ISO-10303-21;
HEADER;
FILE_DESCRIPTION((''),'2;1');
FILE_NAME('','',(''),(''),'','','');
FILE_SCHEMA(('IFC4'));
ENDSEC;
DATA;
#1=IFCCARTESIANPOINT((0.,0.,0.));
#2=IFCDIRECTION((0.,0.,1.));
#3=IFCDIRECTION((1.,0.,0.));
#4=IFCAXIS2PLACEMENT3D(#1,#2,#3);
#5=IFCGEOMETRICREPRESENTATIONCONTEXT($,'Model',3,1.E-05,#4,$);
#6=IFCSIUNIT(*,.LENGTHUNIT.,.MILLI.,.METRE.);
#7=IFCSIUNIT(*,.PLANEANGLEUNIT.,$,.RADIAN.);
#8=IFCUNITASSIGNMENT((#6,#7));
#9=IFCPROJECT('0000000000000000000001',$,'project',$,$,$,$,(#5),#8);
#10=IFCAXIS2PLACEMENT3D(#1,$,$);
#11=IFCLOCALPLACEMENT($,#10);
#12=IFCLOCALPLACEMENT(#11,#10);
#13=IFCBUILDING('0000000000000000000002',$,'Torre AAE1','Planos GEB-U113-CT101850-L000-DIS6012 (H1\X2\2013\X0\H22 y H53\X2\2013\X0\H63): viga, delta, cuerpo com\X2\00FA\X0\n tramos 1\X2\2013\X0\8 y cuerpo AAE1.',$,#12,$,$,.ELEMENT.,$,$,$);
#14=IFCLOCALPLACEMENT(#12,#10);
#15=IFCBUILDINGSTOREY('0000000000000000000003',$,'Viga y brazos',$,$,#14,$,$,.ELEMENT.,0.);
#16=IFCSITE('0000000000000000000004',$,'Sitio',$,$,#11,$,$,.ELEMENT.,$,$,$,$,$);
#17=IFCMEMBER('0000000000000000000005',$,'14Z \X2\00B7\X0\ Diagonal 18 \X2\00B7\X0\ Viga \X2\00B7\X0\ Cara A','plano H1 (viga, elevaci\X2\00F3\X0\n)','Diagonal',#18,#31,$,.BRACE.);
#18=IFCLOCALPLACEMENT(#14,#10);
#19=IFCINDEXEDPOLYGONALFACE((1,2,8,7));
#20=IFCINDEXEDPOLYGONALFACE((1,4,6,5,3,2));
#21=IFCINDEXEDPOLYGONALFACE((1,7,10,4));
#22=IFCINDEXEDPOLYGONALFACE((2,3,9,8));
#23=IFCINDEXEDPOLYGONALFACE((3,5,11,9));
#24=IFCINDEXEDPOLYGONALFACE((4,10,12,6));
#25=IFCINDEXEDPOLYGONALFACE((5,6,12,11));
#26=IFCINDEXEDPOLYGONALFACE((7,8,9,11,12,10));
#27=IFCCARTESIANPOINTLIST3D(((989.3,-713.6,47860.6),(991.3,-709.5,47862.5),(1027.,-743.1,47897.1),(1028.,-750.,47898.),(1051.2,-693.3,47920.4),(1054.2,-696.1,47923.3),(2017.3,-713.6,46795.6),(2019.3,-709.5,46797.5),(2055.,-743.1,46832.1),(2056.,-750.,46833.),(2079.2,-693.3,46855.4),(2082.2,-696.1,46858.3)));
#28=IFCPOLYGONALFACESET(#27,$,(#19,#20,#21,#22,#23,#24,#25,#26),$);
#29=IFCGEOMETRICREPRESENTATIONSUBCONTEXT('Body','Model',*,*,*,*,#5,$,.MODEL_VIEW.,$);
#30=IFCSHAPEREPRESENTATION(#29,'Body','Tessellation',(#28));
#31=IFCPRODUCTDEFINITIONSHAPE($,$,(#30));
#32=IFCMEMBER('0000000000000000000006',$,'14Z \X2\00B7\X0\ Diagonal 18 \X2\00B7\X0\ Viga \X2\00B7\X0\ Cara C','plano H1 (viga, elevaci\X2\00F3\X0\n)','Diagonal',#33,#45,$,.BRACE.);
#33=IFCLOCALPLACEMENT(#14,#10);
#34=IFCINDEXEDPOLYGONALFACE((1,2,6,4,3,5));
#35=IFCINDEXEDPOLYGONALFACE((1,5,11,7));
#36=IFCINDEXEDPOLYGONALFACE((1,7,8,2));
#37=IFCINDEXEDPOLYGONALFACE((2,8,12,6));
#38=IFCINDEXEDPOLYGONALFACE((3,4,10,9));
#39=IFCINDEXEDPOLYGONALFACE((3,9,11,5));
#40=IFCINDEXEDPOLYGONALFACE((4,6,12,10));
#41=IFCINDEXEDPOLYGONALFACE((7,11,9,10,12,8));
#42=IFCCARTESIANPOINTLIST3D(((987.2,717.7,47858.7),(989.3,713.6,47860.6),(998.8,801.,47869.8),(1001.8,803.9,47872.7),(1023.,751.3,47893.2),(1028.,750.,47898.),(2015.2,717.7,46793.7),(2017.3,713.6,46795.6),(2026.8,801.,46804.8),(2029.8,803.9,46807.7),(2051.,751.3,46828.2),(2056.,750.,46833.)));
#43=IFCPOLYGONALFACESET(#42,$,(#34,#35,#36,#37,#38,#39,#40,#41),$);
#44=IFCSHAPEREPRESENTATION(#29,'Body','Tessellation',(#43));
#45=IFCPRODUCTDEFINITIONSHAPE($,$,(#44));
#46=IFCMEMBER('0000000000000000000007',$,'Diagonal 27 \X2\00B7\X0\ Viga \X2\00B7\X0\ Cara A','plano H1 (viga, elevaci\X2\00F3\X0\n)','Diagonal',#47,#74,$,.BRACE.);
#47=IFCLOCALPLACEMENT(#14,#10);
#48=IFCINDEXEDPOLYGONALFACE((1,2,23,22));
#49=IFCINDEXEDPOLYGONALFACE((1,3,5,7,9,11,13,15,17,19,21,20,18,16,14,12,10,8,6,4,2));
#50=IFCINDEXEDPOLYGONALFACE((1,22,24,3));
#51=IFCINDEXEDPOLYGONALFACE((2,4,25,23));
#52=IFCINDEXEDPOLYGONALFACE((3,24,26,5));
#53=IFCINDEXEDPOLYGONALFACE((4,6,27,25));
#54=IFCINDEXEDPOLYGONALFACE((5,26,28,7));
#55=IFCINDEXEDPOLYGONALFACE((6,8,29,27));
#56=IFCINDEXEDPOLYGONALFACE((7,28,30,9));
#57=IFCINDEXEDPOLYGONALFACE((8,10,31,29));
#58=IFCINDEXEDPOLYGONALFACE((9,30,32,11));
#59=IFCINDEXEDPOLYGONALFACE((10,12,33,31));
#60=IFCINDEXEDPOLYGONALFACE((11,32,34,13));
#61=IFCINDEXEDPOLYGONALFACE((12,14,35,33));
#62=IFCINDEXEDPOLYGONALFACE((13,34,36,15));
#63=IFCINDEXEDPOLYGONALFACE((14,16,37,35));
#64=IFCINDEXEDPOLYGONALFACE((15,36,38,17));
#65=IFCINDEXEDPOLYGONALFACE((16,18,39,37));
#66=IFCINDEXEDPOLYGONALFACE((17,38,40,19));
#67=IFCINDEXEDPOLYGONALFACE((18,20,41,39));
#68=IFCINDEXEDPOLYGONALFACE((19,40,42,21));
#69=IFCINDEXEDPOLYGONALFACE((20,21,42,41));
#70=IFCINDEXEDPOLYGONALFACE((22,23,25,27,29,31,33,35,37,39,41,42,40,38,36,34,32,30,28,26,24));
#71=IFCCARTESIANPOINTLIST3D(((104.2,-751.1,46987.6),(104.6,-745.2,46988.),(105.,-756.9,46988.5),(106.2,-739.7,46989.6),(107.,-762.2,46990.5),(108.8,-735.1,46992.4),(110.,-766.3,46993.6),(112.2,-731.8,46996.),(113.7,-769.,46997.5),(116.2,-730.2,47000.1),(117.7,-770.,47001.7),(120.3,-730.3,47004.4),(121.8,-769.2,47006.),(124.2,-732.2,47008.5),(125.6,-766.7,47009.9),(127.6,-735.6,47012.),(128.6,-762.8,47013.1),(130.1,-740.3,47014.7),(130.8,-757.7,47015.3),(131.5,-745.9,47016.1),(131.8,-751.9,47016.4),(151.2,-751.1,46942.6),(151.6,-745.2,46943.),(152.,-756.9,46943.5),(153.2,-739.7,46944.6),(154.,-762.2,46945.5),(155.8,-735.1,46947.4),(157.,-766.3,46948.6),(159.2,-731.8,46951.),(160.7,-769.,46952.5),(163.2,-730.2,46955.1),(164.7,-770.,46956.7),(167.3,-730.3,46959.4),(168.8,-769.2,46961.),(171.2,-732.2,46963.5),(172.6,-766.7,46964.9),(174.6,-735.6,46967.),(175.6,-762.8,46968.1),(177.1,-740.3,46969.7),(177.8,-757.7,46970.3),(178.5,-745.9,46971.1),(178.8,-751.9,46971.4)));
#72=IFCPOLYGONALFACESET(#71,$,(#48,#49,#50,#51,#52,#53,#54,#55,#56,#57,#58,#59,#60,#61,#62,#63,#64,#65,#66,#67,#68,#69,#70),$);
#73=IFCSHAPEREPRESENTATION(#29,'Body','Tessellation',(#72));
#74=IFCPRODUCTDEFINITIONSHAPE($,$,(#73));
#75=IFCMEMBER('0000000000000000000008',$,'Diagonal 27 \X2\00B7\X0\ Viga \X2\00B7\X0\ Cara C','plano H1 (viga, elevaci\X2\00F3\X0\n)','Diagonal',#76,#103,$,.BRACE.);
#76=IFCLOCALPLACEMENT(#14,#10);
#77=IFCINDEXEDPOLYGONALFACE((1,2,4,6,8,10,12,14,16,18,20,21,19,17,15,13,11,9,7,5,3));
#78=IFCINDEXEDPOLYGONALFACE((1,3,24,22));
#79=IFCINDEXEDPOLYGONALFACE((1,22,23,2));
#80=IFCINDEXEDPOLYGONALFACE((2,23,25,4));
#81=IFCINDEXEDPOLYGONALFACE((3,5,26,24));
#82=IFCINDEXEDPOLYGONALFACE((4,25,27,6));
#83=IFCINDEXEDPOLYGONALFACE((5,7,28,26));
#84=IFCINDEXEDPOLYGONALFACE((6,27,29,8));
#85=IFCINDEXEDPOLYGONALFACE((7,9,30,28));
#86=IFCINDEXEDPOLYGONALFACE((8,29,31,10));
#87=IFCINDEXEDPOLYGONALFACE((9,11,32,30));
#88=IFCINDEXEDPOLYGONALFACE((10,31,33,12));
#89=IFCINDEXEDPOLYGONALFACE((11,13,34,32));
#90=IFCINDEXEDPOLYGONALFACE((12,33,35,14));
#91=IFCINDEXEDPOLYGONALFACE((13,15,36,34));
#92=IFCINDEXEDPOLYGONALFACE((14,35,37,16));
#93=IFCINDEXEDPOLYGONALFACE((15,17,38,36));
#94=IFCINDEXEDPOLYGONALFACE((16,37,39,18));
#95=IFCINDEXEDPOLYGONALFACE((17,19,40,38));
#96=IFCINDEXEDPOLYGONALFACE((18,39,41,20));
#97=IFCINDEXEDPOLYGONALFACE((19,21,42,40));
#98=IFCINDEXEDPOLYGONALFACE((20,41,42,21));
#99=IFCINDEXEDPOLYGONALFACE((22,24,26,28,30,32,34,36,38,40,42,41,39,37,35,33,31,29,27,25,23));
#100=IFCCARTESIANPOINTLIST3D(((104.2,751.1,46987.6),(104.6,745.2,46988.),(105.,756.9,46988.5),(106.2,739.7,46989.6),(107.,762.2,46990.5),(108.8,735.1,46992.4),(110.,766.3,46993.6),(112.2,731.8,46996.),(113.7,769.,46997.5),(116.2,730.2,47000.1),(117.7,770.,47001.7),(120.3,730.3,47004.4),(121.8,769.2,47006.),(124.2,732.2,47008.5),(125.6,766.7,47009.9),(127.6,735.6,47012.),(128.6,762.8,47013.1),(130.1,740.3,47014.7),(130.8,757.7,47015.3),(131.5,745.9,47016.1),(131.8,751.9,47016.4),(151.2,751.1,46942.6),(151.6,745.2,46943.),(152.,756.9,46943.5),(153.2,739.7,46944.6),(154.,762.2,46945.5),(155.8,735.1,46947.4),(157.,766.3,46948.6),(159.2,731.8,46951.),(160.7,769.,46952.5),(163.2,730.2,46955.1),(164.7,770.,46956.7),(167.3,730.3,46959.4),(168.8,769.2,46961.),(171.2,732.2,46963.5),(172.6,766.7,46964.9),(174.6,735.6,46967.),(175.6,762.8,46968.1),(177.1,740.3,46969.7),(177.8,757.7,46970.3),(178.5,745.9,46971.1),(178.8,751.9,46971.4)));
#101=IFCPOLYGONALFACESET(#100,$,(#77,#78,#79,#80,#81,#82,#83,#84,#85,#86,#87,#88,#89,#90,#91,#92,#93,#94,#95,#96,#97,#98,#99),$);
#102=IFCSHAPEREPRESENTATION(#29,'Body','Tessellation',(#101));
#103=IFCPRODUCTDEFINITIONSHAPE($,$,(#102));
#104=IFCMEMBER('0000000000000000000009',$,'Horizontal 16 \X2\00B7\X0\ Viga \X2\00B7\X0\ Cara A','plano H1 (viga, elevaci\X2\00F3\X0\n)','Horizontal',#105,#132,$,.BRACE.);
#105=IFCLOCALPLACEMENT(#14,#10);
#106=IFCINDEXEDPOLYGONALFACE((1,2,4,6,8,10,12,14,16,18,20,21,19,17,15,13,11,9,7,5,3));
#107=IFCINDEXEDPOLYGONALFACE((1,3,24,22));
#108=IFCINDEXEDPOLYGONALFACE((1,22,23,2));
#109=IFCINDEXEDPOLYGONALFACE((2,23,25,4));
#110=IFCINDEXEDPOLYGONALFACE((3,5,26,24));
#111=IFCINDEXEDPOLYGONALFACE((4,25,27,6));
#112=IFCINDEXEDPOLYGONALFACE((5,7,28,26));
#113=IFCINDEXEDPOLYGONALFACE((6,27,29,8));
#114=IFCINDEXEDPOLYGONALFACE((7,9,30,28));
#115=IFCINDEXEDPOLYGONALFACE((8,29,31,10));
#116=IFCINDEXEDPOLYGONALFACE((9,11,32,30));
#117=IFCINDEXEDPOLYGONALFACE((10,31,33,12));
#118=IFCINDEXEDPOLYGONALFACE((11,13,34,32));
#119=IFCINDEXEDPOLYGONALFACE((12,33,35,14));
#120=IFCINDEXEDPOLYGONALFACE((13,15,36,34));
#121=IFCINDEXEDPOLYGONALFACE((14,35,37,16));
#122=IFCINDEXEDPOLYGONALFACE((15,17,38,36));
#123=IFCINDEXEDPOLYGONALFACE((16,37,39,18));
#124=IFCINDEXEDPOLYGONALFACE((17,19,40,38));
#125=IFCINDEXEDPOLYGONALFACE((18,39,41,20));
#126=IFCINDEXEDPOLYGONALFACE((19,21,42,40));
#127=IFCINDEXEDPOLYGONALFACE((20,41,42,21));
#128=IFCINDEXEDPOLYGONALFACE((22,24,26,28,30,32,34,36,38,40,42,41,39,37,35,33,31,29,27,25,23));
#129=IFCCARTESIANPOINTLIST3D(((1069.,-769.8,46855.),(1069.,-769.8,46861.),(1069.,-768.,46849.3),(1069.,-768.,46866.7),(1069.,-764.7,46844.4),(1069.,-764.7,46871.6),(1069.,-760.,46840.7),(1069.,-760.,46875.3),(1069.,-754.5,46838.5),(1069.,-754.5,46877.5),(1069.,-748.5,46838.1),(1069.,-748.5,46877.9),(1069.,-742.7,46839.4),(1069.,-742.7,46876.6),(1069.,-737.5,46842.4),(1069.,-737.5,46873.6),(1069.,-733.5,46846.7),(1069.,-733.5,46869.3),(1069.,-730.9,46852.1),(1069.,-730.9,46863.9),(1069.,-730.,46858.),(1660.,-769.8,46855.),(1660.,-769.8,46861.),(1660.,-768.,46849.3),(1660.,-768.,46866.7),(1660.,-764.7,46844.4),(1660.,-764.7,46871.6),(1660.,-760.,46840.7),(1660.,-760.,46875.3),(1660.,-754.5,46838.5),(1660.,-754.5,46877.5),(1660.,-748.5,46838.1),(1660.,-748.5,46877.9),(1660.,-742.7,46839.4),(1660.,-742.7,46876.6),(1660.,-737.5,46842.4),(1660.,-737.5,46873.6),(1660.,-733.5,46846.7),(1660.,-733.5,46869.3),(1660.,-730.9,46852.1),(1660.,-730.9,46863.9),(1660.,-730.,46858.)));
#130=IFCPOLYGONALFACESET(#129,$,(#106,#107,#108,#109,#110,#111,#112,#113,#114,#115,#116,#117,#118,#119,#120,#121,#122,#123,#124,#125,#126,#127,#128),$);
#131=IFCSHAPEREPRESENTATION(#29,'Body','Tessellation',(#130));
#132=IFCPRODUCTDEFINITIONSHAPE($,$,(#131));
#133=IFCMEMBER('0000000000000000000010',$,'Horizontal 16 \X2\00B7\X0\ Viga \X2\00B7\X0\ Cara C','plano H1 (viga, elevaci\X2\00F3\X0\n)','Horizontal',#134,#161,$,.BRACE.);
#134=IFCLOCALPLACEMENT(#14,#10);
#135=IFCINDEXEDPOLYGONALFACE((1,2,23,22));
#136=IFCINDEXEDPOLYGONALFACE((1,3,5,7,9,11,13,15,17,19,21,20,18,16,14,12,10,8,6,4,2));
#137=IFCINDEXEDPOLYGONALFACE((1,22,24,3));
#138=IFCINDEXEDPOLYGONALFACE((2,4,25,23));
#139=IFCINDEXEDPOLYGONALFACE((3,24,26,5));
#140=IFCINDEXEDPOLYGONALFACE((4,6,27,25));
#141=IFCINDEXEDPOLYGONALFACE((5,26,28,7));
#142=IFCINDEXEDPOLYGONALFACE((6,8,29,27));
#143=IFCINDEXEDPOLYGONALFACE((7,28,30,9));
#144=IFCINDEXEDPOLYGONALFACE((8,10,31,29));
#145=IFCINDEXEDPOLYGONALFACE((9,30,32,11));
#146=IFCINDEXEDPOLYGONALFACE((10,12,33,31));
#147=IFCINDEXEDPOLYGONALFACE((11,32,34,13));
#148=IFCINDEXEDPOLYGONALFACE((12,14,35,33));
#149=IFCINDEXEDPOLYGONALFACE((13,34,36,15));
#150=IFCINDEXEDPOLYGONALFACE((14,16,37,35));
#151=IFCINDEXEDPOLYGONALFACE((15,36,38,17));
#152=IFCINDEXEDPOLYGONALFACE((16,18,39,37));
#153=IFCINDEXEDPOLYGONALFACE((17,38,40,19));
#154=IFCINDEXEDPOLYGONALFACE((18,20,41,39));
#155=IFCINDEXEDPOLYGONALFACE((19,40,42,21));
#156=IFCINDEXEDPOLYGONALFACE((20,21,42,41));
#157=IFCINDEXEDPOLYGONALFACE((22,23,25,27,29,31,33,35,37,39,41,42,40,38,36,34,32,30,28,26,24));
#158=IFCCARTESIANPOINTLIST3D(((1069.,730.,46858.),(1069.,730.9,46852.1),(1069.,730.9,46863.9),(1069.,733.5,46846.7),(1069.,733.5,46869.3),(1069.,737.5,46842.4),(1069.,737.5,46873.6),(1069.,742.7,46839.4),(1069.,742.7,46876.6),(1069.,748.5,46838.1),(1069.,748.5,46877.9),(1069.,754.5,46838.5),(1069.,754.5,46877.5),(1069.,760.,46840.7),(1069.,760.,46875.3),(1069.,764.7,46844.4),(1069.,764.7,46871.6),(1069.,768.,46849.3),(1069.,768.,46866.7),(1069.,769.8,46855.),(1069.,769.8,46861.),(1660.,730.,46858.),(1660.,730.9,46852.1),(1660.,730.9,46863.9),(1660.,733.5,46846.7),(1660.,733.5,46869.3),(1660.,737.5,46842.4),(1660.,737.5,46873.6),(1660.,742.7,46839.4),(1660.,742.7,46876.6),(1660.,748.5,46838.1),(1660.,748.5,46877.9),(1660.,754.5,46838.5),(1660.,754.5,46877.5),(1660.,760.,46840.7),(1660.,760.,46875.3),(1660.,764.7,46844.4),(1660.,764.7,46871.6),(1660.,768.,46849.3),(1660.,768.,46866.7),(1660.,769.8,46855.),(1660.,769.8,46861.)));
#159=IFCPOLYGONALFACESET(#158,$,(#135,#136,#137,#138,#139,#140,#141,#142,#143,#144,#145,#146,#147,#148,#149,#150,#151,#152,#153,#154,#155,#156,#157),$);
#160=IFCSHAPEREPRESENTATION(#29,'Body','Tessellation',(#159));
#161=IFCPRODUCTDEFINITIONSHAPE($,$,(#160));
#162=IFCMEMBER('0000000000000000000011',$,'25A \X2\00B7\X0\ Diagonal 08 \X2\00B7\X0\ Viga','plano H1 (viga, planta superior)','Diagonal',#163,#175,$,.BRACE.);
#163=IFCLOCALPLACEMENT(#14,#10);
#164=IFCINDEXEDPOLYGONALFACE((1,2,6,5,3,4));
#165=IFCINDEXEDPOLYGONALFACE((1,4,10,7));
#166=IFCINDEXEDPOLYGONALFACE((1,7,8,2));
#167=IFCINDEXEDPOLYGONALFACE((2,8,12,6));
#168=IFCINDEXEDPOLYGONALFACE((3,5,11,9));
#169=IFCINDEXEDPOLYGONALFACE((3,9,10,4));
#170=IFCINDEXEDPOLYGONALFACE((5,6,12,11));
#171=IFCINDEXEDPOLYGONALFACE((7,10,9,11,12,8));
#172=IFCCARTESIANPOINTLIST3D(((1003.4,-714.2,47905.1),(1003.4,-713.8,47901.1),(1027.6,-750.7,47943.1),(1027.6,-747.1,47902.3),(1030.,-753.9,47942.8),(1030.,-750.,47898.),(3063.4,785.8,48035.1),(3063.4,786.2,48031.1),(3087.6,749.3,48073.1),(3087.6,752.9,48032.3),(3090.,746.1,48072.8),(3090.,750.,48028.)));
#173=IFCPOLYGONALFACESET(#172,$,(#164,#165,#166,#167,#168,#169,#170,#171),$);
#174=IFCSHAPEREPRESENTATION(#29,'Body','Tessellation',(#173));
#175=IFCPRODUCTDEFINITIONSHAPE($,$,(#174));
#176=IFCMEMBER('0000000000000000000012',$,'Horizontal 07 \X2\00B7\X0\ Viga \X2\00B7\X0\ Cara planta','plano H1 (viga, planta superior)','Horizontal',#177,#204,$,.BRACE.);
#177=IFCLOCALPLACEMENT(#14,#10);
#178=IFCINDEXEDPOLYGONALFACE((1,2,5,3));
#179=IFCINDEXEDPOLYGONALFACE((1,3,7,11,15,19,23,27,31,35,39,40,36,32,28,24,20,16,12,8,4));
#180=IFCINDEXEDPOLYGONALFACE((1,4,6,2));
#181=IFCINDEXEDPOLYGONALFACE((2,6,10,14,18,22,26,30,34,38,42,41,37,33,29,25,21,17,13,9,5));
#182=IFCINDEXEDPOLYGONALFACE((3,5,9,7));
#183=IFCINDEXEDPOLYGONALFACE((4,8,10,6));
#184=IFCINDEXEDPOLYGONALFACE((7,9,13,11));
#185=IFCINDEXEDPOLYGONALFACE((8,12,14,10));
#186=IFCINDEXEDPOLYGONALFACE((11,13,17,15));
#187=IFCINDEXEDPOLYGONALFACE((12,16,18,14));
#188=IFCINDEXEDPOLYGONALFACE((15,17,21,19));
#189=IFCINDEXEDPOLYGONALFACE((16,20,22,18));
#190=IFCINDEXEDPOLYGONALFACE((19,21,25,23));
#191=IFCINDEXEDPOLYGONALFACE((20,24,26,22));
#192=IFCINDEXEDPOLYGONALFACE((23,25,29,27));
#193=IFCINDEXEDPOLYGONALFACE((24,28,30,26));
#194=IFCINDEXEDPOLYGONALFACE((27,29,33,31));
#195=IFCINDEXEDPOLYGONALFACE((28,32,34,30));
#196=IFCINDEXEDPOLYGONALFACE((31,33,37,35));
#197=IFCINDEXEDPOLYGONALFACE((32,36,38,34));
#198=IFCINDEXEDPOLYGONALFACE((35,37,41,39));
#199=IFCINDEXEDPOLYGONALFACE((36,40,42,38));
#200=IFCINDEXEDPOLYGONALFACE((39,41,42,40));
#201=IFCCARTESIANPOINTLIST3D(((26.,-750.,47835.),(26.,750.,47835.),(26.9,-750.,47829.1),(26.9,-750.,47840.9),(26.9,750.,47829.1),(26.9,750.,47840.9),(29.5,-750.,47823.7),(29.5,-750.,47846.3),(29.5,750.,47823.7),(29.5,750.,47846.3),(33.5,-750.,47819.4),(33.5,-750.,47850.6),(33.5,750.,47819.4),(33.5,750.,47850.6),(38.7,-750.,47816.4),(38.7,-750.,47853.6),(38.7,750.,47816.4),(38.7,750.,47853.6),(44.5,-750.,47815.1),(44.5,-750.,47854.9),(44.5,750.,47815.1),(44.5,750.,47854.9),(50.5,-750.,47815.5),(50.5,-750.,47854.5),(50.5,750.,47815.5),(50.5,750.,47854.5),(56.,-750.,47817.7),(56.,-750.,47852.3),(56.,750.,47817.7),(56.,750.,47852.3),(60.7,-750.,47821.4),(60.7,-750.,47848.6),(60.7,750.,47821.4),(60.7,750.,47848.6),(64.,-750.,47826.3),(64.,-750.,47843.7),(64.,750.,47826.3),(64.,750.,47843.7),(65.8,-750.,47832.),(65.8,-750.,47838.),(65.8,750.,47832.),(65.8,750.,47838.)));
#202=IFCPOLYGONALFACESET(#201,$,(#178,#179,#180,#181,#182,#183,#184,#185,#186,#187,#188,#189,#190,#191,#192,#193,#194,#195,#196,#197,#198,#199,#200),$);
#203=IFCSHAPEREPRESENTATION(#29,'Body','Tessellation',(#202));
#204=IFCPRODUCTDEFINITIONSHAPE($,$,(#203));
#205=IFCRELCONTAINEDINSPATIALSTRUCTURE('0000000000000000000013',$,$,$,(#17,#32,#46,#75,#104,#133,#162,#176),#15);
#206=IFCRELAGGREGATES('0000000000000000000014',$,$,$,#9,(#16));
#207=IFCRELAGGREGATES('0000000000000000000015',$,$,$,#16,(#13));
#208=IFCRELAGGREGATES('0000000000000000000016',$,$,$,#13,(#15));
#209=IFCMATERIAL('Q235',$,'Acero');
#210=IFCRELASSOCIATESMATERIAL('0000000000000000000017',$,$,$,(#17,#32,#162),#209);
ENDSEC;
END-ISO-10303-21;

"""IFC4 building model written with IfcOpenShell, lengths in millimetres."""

from ifc_helpers import new_model, si_unit, frame, frame_2d, origin, origin_with_axes, place, context, subcontext, project, spatial, circle, l_section, extrude, material, element, save


model = new_model("IFC4")

# Units and contexts
model_context = context("Model", 3, precision=1e-05, world=origin_with_axes())
body_context = subcontext(model_context, "Body", "Model", "MODEL_VIEW")
ifc_project = project(units=[si_unit("LENGTHUNIT", "METRE", prefix="MILLI"), si_unit("PLANEANGLEUNIT", "RADIAN")], contexts=[model_context])

# Site, building, storey
site_placement = place(None, origin())
site = spatial("IfcSite", under=ifc_project, at=site_placement, Name="Sitio", CompositionType="ELEMENT")
building_placement = place(site_placement, origin())
building = spatial("IfcBuilding", under=site, at=building_placement, Name="Torre AAE1", Description="Planos GEB-U113-CT101850-L000-DIS6012 (H1–H22 y H53–H63): viga, delta, cuerpo común tramos 1–8 y cuerpo AAE1.", CompositionType="ELEMENT")
storey_placement = place(building_placement, origin())
storey = spatial("IfcBuildingStorey", under=building, at=storey_placement, Name="Viga y brazos", CompositionType="ELEMENT", Elevation=0.0)

# Members
ifc_material = material(Name="Q235", Category="Acero")
for number, where, z_axis, x_axis, name in (
    (1, (1028.0, -750.0, 47898.0), (0.694498, 0.0, -0.719495), (-0.596074, 0.560044, -0.575366), "14Z · Diagonal 18 · Viga · Cara A"),
    (2, (1028.0, 750.0, 47898.0), (0.694498, 0.0, -0.719495), (-0.596074, -0.560044, -0.575366), "14Z · Diagonal 18 · Viga · Cara C"),
):
    element("IfcMember", number, at=place(storey_placement, frame(where, z_axis=z_axis, x_axis=x_axis)), inside=storey, material=ifc_material, Name=name, Description="plano H1 (viga, elevación)", ObjectType="Diagonal", PredefinedType="BRACE", context=body_context, shape_type="SweptSolid", body=[
        extrude(l_section(Depth=65.0, Width=65.0, Thickness=5.0, at=frame_2d((32.5, 32.5))), None, (0.0, 0.0, 1.0), 1480.2),
    ])
for number, where, z_axis, x_axis, name in (
    (3, (165.0, -750.0, 46957.0), (-0.722308, 0.0, 0.691571), (-0.089475, 0.991595, -0.093452), "Diagonal 27 · Viga · Cara A"),
    (4, (165.0, 750.0, 46957.0), (-0.722308, 0.0, 0.691571), (-0.089475, -0.991595, -0.093452), "Diagonal 27 · Viga · Cara C"),
):
    element("IfcMember", number, at=place(storey_placement, frame(where, z_axis=z_axis, x_axis=x_axis)), inside=storey, Name=name, Description="plano H1 (viga, elevación)", ObjectType="Diagonal", PredefinedType="BRACE", context=body_context, shape_type="SweptSolid", body=[
        extrude(circle(Radius=20.0), None, (0.0, 0.0, 1.0), 65.1),
    ])
for number, where, z_axis, x_axis, name in (
    (5, (1069.0, -750.0, 46858.0), (1.0, 0.0, 0.0), (0.0, 1.0, 0.0), "Horizontal 16 · Viga · Cara A"),
    (6, (1069.0, 750.0, 46858.0), (1.0, 0.0, 0.0), (0.0, -1.0, 0.0), "Horizontal 16 · Viga · Cara C"),
):
    element("IfcMember", number, at=place(storey_placement, frame(where, z_axis=z_axis, x_axis=x_axis)), inside=storey, Name=name, Description="plano H1 (viga, elevación)", ObjectType="Horizontal", PredefinedType="BRACE", context=body_context, shape_type="SweptSolid", body=[
        extrude(circle(Radius=20.0), None, (0.0, 0.0, 1.0), 591.0),
    ])
member_1_placement = place(storey_placement, frame((1030.0, -750.0, 47898.0), z_axis=(0.807347, 0.587874, 0.050949), x_axis=(-0.590077, 0.804332, 0.069709)))
element("IfcMember", 7, at=member_1_placement, inside=storey, material=ifc_material, Name="25A · Diagonal 08 · Viga", Description="plano H1 (viga, planta superior)", ObjectType="Diagonal", PredefinedType="BRACE", context=body_context, shape_type="SweptSolid", body=[
    extrude(l_section(Depth=45.0, Width=45.0, Thickness=4.0, at=frame_2d((22.5, 22.5))), None, (0.0, 0.0, 1.0), 2551.6),
])
member_2_placement = place(storey_placement, frame((46.0, 750.0, 47835.0), z_axis=(0.0, -1.0, 0.0), x_axis=(-1.0, 0.0, 0.0)))
element("IfcMember", 8, at=member_2_placement, inside=storey, Name="Horizontal 07 · Viga · Cara planta", Description="plano H1 (viga, planta superior)", ObjectType="Horizontal", PredefinedType="BRACE", context=body_context, shape_type="SweptSolid", body=[
    extrude(circle(Radius=20.0), None, (0.0, 0.0, 1.0), 1500.0),
])

save(model, "model.ifc")
